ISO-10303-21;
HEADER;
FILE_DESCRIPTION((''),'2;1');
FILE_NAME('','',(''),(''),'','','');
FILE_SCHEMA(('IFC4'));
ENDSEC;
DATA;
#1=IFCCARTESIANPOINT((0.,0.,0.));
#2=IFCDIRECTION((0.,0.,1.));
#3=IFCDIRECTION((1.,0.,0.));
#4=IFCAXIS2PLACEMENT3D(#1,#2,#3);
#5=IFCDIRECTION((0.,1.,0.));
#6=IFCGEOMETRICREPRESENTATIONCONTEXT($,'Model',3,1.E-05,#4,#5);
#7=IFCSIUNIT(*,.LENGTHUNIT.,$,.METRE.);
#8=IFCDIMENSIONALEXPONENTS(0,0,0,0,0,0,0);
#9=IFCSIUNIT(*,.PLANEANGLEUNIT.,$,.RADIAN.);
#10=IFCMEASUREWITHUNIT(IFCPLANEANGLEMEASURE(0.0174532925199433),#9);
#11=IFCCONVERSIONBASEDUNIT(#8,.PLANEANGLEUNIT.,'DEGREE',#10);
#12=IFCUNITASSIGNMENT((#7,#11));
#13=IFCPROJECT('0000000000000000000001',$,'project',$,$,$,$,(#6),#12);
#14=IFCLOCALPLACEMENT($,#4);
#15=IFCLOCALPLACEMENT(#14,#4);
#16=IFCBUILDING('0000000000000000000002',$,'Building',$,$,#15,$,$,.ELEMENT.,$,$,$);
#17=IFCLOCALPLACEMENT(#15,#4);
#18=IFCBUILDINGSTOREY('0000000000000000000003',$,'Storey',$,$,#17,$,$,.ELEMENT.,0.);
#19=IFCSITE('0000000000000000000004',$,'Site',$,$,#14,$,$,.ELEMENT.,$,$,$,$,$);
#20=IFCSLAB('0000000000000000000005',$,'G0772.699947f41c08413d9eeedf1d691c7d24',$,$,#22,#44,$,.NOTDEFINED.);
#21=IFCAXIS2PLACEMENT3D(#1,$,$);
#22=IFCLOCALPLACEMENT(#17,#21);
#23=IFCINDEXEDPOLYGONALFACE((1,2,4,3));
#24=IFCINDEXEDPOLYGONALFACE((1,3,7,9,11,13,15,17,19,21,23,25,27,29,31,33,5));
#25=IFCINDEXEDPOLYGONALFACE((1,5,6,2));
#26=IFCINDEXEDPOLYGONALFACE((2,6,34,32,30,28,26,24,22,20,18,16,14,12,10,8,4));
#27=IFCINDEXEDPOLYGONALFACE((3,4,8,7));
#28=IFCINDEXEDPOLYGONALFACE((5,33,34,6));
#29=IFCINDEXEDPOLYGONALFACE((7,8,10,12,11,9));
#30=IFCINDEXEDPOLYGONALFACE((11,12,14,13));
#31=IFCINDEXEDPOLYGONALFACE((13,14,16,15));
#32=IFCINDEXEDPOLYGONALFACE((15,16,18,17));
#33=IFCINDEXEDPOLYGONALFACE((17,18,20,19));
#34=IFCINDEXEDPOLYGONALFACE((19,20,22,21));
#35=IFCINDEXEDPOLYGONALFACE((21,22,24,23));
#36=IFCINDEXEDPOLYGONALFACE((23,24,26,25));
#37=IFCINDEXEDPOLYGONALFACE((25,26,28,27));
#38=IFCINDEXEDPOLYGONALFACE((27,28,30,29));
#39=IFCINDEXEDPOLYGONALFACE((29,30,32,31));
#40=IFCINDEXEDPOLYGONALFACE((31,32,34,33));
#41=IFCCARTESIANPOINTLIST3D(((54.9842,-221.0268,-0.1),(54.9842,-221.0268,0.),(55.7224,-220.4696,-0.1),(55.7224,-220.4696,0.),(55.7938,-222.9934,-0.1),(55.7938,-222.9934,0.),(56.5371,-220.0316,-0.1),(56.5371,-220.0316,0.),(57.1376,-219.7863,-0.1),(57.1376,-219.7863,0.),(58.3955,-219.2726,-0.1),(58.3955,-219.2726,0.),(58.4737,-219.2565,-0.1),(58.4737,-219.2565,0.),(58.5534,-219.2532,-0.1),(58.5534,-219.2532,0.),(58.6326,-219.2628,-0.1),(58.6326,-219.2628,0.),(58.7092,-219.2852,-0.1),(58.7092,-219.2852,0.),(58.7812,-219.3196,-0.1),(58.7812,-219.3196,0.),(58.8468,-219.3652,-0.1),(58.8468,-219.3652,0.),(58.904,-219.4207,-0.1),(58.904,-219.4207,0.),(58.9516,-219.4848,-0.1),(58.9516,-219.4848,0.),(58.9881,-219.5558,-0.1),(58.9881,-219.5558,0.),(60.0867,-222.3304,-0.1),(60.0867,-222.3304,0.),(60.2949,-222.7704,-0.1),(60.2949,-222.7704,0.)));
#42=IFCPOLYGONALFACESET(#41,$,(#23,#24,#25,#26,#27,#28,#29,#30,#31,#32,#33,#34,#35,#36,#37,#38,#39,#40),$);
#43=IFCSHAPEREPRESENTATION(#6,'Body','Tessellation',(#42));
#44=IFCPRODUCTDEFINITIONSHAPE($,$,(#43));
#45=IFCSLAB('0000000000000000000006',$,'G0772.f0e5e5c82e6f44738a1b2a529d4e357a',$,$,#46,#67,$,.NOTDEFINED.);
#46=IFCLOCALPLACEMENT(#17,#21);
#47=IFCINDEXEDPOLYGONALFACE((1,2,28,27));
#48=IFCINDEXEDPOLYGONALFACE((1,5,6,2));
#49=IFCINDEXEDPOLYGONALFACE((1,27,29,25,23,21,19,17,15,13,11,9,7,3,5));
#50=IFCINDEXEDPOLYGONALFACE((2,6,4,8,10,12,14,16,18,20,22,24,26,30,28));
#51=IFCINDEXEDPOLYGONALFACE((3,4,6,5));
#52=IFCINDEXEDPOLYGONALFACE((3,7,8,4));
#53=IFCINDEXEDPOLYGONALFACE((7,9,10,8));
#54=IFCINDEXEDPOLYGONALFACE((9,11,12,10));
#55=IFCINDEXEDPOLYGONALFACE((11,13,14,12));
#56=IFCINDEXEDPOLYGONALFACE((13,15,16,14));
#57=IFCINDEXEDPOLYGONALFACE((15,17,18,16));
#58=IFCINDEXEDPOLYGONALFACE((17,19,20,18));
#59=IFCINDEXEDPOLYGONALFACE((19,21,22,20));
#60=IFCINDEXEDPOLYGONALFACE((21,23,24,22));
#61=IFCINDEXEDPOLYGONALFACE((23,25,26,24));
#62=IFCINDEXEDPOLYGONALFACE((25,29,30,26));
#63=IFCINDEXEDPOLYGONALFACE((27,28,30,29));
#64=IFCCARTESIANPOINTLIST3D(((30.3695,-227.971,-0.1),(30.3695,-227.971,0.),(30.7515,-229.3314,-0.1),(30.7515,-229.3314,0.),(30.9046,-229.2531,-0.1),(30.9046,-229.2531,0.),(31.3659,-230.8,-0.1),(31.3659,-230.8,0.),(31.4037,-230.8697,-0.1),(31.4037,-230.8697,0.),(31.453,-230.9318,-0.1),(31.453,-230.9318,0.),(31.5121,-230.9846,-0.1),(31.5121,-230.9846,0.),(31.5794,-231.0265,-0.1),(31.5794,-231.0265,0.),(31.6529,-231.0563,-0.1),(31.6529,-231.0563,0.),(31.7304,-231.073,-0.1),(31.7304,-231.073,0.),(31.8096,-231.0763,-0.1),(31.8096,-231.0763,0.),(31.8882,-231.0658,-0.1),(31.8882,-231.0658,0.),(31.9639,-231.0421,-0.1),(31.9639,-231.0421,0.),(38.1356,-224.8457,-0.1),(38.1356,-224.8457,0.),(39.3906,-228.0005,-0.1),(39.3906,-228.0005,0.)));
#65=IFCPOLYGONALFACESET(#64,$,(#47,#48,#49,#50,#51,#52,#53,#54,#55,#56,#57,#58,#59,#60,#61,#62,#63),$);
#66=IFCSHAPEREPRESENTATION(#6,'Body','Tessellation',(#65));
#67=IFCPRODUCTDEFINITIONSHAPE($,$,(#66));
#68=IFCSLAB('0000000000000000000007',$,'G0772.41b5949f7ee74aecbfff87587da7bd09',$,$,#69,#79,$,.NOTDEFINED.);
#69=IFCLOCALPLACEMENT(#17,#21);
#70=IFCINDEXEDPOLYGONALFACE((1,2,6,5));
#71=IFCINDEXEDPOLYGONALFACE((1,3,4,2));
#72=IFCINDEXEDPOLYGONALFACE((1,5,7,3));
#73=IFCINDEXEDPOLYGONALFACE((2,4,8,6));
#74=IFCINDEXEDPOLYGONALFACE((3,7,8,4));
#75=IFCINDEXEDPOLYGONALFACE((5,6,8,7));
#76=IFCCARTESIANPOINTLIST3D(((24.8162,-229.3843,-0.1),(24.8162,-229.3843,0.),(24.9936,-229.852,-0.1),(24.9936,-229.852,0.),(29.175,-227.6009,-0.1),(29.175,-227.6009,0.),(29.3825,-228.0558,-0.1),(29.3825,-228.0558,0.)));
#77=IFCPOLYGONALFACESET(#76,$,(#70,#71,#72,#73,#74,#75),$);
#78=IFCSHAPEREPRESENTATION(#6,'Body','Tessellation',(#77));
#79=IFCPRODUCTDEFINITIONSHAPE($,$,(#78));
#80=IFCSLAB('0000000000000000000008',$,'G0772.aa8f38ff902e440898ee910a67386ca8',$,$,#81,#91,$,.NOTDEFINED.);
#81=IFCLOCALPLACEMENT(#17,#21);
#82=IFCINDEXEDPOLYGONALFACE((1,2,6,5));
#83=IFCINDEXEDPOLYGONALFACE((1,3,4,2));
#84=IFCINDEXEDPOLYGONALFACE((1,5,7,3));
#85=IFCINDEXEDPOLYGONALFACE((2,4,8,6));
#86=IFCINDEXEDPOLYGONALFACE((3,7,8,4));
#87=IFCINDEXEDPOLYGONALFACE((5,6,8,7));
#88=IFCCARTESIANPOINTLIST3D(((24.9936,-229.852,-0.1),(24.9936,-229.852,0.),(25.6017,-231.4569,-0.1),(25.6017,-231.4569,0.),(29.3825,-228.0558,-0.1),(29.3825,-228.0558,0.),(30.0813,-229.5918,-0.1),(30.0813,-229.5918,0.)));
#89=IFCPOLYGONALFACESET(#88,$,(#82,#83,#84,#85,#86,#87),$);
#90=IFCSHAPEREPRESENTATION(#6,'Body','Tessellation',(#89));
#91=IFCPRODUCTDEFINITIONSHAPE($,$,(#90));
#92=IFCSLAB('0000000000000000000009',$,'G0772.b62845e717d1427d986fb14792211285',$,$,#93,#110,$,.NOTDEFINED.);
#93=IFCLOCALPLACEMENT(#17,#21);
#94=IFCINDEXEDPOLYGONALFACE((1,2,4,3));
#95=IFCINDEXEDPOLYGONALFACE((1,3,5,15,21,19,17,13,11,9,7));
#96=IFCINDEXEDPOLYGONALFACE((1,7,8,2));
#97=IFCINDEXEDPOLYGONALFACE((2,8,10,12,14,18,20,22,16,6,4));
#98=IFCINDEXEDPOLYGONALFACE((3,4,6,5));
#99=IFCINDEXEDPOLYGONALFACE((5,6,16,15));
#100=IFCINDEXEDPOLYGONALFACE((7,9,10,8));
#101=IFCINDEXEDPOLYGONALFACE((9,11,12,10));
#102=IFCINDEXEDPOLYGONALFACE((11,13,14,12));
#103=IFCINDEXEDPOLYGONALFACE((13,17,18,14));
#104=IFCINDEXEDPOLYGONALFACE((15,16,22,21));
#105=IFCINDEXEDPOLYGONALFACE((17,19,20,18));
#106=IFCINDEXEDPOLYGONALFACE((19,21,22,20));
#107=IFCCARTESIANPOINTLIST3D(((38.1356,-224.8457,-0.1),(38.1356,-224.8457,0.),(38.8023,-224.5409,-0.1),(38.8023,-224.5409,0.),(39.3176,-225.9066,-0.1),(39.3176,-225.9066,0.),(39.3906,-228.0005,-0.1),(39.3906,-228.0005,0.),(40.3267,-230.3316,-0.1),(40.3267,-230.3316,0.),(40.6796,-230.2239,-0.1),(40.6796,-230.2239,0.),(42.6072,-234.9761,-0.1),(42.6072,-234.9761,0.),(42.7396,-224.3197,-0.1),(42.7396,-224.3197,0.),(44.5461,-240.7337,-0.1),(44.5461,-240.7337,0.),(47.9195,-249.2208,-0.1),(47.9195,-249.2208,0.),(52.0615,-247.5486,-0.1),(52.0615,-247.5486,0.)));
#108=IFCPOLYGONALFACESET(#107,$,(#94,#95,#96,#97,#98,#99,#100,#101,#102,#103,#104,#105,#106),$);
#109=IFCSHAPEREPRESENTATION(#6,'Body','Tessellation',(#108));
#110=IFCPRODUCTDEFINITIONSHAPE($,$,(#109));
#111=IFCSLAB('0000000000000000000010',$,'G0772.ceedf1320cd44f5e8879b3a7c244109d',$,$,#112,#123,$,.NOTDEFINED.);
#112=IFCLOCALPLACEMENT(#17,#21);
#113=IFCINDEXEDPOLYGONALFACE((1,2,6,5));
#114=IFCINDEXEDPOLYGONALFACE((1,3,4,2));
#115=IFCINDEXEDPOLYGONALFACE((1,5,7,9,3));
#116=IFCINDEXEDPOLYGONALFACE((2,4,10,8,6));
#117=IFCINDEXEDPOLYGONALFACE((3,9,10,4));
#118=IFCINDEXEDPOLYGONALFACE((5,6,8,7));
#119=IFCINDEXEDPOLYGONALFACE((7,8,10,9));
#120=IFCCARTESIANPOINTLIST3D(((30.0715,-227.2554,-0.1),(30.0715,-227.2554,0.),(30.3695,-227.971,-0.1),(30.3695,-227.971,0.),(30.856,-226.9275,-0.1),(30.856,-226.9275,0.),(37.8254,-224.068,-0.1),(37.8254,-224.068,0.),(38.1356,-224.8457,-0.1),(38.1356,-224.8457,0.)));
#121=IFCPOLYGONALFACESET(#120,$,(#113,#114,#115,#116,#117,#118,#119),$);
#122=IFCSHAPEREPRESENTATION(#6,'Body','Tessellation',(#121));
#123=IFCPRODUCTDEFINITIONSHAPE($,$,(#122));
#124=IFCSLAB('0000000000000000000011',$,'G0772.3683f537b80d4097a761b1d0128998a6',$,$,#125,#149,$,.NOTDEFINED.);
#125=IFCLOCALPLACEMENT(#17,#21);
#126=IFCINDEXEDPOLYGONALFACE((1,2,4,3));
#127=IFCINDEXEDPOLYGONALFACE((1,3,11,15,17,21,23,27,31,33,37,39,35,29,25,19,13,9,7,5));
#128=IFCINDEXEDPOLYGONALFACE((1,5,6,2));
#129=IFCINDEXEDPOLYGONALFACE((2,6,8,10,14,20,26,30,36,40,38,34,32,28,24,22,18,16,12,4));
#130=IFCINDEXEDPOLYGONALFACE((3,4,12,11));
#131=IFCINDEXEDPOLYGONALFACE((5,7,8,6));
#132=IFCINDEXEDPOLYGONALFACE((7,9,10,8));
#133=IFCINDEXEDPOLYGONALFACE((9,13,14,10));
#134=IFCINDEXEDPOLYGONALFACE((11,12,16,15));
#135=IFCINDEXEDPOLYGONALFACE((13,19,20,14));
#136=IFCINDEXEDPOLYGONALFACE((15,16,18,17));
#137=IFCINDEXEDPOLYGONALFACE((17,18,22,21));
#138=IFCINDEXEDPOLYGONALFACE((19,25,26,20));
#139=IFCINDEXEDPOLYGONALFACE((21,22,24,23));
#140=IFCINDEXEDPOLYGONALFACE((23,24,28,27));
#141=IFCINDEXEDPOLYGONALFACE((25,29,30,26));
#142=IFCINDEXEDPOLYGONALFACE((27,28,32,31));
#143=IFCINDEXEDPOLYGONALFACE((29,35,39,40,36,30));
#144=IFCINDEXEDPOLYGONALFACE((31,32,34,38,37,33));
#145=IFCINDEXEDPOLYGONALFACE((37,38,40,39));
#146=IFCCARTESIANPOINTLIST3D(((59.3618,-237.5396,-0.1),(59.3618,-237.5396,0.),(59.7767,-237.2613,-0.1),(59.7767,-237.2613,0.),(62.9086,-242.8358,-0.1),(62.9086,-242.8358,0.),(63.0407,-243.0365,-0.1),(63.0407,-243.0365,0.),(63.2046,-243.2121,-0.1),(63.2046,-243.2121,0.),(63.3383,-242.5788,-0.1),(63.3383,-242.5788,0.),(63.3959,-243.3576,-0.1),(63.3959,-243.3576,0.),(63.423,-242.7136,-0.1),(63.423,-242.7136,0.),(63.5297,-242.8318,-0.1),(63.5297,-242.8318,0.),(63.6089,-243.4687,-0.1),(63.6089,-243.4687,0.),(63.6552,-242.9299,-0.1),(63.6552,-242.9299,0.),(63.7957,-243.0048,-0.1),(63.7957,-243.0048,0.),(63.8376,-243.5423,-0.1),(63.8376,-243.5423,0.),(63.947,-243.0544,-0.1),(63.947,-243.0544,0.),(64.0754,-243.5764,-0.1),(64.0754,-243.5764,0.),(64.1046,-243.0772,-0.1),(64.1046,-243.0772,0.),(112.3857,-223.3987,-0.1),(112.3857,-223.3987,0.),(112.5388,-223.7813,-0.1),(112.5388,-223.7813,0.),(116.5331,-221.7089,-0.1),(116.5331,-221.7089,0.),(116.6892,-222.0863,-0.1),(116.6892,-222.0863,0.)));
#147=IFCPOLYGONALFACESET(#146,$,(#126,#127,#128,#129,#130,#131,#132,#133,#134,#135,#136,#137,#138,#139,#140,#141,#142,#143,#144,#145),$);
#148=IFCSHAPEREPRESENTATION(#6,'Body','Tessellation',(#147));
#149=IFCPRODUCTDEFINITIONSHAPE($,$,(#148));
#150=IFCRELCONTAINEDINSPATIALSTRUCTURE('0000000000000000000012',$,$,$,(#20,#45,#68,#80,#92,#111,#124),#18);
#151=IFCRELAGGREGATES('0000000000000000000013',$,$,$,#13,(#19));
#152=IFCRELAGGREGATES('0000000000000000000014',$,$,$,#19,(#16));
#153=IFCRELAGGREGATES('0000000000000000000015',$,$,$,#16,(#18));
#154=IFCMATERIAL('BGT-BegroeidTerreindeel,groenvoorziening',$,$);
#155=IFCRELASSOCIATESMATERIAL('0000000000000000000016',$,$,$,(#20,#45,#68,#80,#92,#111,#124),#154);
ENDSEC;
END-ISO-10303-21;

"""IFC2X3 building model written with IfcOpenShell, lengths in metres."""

from ifc_helpers import new_model, entity, si_unit, converted_unit, direction, frame, origin_with_axes, place, context, project, spatial, polyline, outline, extrude, material, element, save


model = new_model("IFC2X3")

# Units and contexts
model_context = context("Model", 3, precision=1e-05, world=origin_with_axes(), true_north=direction((0.0, 1.0, 0.0)))
ifc_project = project(units=[si_unit("LENGTHUNIT", "METRE"), converted_unit("PLANEANGLEUNIT", "DEGREE", entity("IfcPlaneAngleMeasure", 0.0174532925199433), si_unit("PLANEANGLEUNIT", "RADIAN"), dimensions=[0, 0, 0, 0, 0, 0, 0])], contexts=[model_context])

# Site, building, storey
site_placement = place(None, origin_with_axes())
site = spatial("IfcSite", under=ifc_project, at=site_placement, Name="Site", CompositionType="ELEMENT")
building_placement = place(site_placement, origin_with_axes())
building = spatial("IfcBuilding", under=site, at=building_placement, Name="Building", CompositionType="ELEMENT")
storey_placement = place(building_placement, origin_with_axes())
storey = spatial("IfcBuildingStorey", under=building, at=storey_placement, Name="Storey", CompositionType="ELEMENT", Elevation=0.0)

# Slabs
ifc_material_1 = material(Name="BGT-BegroeidTerreindeel,groenvoorziening")
slab_1_placement = place(storey_placement, frame((0.0, 0.0, -0.1), z_axis=(0.0, 0.0, 1.0), x_axis=(1.0, 0.0, 0.0)))
element("IfcSlab", 1, at=slab_1_placement, inside=storey, material=ifc_material_1, Name="G0772.699947f41c08413d9eeedf1d691c7d24", PredefinedType="NOTDEFINED", context=model_context, shape_type="SweptSolid", body=[
    extrude(outline(polyline([(60.0867, -222.3304), (60.2949, -222.7704), (55.7938, -222.9934), (54.9842, -221.0268), (55.7224, -220.4696), (56.5371, -220.0316), (57.1376, -219.7863), (58.3955, -219.2726), (58.4737, -219.2565), (58.5534, -219.2532), (58.6326, -219.2628), (58.7092, -219.2852), (58.7812, -219.3196), (58.8468, -219.3652), (58.904, -219.4207), (58.9516, -219.4848), (58.9881, -219.5558), (60.0867, -222.3304)])), origin_with_axes(), (0.0, 0.0, 1.0), 0.1),
])
slab_2_placement = place(storey_placement, frame((0.0, 0.0, -0.1), z_axis=(0.0, 0.0, 1.0), x_axis=(1.0, 0.0, 0.0)))
element("IfcSlab", 2, at=slab_2_placement, inside=storey, material=ifc_material_1, Name="G0772.f0e5e5c82e6f44738a1b2a529d4e357a", PredefinedType="NOTDEFINED", context=model_context, shape_type="SweptSolid", body=[
    extrude(outline(polyline([(38.1356, -224.8457), (39.3906, -228.0005), (31.9639, -231.0421), (31.8882, -231.0658), (31.8096, -231.0763), (31.7304, -231.073), (31.6529, -231.0563), (31.5794, -231.0265), (31.5121, -230.9846), (31.453, -230.9318), (31.4037, -230.8697), (31.3659, -230.8), (30.7515, -229.3314), (30.9046, -229.2531), (30.3695, -227.971), (38.1356, -224.8457)])), origin_with_axes(), (0.0, 0.0, 1.0), 0.1),
])
slab_3_placement = place(storey_placement, frame((0.0, 0.0, -0.1), z_axis=(0.0, 0.0, 1.0), x_axis=(1.0, 0.0, 0.0)))
element("IfcSlab", 3, at=slab_3_placement, inside=storey, material=ifc_material_1, Name="G0772.41b5949f7ee74aecbfff87587da7bd09", PredefinedType="NOTDEFINED", context=model_context, shape_type="SweptSolid", body=[
    extrude(outline(polyline([(29.3825, -228.0558), (24.9936, -229.852), (24.8162, -229.3843), (29.175, -227.6009), (29.3825, -228.0558)])), origin_with_axes(), (0.0, 0.0, 1.0), 0.1),
])
slab_4_placement = place(storey_placement, frame((0.0, 0.0, -0.1), z_axis=(0.0, 0.0, 1.0), x_axis=(1.0, 0.0, 0.0)))
element("IfcSlab", 4, at=slab_4_placement, inside=storey, material=ifc_material_1, Name="G0772.aa8f38ff902e440898ee910a67386ca8", PredefinedType="NOTDEFINED", context=model_context, shape_type="SweptSolid", body=[
    extrude(outline(polyline([(29.3825, -228.0558), (30.0813, -229.5918), (25.6017, -231.4569), (24.9936, -229.852), (29.3825, -228.0558)])), origin_with_axes(), (0.0, 0.0, 1.0), 0.1),
])
slab_5_placement = place(storey_placement, frame((0.0, 0.0, -0.1), z_axis=(0.0, 0.0, 1.0), x_axis=(1.0, 0.0, 0.0)))
element("IfcSlab", 5, at=slab_5_placement, inside=storey, material=ifc_material_1, Name="G0772.b62845e717d1427d986fb14792211285", PredefinedType="NOTDEFINED", context=model_context, shape_type="SweptSolid", body=[
    extrude(outline(polyline([(38.8023, -224.5409), (39.3176, -225.9066), (42.7396, -224.3197), (52.0615, -247.5486), (47.9195, -249.2208), (44.5461, -240.7337), (42.6072, -234.9761), (40.6796, -230.2239), (40.3267, -230.3316), (39.3906, -228.0005), (38.1356, -224.8457), (38.8023, -224.5409)])), origin_with_axes(), (0.0, 0.0, 1.0), 0.1),
])
slab_6_placement = place(storey_placement, frame((0.0, 0.0, -0.1), z_axis=(0.0, 0.0, 1.0), x_axis=(1.0, 0.0, 0.0)))
element("IfcSlab", 6, at=slab_6_placement, inside=storey, material=ifc_material_1, Name="G0772.ceedf1320cd44f5e8879b3a7c244109d", PredefinedType="NOTDEFINED", context=model_context, shape_type="SweptSolid", body=[
    extrude(outline(polyline([(37.8254, -224.068), (38.1356, -224.8457), (30.3695, -227.971), (30.0715, -227.2554), (30.856, -226.9275), (37.8254, -224.068)])), origin_with_axes(), (0.0, 0.0, 1.0), 0.1),
])
slab_7_placement = place(storey_placement, frame((0.0, 0.0, -0.1), z_axis=(0.0, 0.0, 1.0), x_axis=(1.0, 0.0, 0.0)))
element("IfcSlab", 7, at=slab_7_placement, inside=storey, material=ifc_material_1, Name="G0772.3683f537b80d4097a761b1d0128998a6", PredefinedType="NOTDEFINED", context=model_context, shape_type="SweptSolid", body=[
    extrude(outline(polyline([(116.5331, -221.7089), (116.6892, -222.0863), (112.5388, -223.7813), (64.0754, -243.5764), (63.8376, -243.5423), (63.6089, -243.4687), (63.3959, -243.3576), (63.2046, -243.2121), (63.0407, -243.0365), (62.9086, -242.8358), (59.3618, -237.5396), (59.7767, -237.2613), (63.3383, -242.5788), (63.423, -242.7136), (63.5297, -242.8318), (63.6552, -242.9299), (63.7957, -243.0048), (63.947, -243.0544), (64.1046, -243.0772), (112.3857, -223.3987), (116.5331, -221.7089)])), origin_with_axes(), (0.0, 0.0, 1.0), 0.1),
])

save(model, "model.ifc")
